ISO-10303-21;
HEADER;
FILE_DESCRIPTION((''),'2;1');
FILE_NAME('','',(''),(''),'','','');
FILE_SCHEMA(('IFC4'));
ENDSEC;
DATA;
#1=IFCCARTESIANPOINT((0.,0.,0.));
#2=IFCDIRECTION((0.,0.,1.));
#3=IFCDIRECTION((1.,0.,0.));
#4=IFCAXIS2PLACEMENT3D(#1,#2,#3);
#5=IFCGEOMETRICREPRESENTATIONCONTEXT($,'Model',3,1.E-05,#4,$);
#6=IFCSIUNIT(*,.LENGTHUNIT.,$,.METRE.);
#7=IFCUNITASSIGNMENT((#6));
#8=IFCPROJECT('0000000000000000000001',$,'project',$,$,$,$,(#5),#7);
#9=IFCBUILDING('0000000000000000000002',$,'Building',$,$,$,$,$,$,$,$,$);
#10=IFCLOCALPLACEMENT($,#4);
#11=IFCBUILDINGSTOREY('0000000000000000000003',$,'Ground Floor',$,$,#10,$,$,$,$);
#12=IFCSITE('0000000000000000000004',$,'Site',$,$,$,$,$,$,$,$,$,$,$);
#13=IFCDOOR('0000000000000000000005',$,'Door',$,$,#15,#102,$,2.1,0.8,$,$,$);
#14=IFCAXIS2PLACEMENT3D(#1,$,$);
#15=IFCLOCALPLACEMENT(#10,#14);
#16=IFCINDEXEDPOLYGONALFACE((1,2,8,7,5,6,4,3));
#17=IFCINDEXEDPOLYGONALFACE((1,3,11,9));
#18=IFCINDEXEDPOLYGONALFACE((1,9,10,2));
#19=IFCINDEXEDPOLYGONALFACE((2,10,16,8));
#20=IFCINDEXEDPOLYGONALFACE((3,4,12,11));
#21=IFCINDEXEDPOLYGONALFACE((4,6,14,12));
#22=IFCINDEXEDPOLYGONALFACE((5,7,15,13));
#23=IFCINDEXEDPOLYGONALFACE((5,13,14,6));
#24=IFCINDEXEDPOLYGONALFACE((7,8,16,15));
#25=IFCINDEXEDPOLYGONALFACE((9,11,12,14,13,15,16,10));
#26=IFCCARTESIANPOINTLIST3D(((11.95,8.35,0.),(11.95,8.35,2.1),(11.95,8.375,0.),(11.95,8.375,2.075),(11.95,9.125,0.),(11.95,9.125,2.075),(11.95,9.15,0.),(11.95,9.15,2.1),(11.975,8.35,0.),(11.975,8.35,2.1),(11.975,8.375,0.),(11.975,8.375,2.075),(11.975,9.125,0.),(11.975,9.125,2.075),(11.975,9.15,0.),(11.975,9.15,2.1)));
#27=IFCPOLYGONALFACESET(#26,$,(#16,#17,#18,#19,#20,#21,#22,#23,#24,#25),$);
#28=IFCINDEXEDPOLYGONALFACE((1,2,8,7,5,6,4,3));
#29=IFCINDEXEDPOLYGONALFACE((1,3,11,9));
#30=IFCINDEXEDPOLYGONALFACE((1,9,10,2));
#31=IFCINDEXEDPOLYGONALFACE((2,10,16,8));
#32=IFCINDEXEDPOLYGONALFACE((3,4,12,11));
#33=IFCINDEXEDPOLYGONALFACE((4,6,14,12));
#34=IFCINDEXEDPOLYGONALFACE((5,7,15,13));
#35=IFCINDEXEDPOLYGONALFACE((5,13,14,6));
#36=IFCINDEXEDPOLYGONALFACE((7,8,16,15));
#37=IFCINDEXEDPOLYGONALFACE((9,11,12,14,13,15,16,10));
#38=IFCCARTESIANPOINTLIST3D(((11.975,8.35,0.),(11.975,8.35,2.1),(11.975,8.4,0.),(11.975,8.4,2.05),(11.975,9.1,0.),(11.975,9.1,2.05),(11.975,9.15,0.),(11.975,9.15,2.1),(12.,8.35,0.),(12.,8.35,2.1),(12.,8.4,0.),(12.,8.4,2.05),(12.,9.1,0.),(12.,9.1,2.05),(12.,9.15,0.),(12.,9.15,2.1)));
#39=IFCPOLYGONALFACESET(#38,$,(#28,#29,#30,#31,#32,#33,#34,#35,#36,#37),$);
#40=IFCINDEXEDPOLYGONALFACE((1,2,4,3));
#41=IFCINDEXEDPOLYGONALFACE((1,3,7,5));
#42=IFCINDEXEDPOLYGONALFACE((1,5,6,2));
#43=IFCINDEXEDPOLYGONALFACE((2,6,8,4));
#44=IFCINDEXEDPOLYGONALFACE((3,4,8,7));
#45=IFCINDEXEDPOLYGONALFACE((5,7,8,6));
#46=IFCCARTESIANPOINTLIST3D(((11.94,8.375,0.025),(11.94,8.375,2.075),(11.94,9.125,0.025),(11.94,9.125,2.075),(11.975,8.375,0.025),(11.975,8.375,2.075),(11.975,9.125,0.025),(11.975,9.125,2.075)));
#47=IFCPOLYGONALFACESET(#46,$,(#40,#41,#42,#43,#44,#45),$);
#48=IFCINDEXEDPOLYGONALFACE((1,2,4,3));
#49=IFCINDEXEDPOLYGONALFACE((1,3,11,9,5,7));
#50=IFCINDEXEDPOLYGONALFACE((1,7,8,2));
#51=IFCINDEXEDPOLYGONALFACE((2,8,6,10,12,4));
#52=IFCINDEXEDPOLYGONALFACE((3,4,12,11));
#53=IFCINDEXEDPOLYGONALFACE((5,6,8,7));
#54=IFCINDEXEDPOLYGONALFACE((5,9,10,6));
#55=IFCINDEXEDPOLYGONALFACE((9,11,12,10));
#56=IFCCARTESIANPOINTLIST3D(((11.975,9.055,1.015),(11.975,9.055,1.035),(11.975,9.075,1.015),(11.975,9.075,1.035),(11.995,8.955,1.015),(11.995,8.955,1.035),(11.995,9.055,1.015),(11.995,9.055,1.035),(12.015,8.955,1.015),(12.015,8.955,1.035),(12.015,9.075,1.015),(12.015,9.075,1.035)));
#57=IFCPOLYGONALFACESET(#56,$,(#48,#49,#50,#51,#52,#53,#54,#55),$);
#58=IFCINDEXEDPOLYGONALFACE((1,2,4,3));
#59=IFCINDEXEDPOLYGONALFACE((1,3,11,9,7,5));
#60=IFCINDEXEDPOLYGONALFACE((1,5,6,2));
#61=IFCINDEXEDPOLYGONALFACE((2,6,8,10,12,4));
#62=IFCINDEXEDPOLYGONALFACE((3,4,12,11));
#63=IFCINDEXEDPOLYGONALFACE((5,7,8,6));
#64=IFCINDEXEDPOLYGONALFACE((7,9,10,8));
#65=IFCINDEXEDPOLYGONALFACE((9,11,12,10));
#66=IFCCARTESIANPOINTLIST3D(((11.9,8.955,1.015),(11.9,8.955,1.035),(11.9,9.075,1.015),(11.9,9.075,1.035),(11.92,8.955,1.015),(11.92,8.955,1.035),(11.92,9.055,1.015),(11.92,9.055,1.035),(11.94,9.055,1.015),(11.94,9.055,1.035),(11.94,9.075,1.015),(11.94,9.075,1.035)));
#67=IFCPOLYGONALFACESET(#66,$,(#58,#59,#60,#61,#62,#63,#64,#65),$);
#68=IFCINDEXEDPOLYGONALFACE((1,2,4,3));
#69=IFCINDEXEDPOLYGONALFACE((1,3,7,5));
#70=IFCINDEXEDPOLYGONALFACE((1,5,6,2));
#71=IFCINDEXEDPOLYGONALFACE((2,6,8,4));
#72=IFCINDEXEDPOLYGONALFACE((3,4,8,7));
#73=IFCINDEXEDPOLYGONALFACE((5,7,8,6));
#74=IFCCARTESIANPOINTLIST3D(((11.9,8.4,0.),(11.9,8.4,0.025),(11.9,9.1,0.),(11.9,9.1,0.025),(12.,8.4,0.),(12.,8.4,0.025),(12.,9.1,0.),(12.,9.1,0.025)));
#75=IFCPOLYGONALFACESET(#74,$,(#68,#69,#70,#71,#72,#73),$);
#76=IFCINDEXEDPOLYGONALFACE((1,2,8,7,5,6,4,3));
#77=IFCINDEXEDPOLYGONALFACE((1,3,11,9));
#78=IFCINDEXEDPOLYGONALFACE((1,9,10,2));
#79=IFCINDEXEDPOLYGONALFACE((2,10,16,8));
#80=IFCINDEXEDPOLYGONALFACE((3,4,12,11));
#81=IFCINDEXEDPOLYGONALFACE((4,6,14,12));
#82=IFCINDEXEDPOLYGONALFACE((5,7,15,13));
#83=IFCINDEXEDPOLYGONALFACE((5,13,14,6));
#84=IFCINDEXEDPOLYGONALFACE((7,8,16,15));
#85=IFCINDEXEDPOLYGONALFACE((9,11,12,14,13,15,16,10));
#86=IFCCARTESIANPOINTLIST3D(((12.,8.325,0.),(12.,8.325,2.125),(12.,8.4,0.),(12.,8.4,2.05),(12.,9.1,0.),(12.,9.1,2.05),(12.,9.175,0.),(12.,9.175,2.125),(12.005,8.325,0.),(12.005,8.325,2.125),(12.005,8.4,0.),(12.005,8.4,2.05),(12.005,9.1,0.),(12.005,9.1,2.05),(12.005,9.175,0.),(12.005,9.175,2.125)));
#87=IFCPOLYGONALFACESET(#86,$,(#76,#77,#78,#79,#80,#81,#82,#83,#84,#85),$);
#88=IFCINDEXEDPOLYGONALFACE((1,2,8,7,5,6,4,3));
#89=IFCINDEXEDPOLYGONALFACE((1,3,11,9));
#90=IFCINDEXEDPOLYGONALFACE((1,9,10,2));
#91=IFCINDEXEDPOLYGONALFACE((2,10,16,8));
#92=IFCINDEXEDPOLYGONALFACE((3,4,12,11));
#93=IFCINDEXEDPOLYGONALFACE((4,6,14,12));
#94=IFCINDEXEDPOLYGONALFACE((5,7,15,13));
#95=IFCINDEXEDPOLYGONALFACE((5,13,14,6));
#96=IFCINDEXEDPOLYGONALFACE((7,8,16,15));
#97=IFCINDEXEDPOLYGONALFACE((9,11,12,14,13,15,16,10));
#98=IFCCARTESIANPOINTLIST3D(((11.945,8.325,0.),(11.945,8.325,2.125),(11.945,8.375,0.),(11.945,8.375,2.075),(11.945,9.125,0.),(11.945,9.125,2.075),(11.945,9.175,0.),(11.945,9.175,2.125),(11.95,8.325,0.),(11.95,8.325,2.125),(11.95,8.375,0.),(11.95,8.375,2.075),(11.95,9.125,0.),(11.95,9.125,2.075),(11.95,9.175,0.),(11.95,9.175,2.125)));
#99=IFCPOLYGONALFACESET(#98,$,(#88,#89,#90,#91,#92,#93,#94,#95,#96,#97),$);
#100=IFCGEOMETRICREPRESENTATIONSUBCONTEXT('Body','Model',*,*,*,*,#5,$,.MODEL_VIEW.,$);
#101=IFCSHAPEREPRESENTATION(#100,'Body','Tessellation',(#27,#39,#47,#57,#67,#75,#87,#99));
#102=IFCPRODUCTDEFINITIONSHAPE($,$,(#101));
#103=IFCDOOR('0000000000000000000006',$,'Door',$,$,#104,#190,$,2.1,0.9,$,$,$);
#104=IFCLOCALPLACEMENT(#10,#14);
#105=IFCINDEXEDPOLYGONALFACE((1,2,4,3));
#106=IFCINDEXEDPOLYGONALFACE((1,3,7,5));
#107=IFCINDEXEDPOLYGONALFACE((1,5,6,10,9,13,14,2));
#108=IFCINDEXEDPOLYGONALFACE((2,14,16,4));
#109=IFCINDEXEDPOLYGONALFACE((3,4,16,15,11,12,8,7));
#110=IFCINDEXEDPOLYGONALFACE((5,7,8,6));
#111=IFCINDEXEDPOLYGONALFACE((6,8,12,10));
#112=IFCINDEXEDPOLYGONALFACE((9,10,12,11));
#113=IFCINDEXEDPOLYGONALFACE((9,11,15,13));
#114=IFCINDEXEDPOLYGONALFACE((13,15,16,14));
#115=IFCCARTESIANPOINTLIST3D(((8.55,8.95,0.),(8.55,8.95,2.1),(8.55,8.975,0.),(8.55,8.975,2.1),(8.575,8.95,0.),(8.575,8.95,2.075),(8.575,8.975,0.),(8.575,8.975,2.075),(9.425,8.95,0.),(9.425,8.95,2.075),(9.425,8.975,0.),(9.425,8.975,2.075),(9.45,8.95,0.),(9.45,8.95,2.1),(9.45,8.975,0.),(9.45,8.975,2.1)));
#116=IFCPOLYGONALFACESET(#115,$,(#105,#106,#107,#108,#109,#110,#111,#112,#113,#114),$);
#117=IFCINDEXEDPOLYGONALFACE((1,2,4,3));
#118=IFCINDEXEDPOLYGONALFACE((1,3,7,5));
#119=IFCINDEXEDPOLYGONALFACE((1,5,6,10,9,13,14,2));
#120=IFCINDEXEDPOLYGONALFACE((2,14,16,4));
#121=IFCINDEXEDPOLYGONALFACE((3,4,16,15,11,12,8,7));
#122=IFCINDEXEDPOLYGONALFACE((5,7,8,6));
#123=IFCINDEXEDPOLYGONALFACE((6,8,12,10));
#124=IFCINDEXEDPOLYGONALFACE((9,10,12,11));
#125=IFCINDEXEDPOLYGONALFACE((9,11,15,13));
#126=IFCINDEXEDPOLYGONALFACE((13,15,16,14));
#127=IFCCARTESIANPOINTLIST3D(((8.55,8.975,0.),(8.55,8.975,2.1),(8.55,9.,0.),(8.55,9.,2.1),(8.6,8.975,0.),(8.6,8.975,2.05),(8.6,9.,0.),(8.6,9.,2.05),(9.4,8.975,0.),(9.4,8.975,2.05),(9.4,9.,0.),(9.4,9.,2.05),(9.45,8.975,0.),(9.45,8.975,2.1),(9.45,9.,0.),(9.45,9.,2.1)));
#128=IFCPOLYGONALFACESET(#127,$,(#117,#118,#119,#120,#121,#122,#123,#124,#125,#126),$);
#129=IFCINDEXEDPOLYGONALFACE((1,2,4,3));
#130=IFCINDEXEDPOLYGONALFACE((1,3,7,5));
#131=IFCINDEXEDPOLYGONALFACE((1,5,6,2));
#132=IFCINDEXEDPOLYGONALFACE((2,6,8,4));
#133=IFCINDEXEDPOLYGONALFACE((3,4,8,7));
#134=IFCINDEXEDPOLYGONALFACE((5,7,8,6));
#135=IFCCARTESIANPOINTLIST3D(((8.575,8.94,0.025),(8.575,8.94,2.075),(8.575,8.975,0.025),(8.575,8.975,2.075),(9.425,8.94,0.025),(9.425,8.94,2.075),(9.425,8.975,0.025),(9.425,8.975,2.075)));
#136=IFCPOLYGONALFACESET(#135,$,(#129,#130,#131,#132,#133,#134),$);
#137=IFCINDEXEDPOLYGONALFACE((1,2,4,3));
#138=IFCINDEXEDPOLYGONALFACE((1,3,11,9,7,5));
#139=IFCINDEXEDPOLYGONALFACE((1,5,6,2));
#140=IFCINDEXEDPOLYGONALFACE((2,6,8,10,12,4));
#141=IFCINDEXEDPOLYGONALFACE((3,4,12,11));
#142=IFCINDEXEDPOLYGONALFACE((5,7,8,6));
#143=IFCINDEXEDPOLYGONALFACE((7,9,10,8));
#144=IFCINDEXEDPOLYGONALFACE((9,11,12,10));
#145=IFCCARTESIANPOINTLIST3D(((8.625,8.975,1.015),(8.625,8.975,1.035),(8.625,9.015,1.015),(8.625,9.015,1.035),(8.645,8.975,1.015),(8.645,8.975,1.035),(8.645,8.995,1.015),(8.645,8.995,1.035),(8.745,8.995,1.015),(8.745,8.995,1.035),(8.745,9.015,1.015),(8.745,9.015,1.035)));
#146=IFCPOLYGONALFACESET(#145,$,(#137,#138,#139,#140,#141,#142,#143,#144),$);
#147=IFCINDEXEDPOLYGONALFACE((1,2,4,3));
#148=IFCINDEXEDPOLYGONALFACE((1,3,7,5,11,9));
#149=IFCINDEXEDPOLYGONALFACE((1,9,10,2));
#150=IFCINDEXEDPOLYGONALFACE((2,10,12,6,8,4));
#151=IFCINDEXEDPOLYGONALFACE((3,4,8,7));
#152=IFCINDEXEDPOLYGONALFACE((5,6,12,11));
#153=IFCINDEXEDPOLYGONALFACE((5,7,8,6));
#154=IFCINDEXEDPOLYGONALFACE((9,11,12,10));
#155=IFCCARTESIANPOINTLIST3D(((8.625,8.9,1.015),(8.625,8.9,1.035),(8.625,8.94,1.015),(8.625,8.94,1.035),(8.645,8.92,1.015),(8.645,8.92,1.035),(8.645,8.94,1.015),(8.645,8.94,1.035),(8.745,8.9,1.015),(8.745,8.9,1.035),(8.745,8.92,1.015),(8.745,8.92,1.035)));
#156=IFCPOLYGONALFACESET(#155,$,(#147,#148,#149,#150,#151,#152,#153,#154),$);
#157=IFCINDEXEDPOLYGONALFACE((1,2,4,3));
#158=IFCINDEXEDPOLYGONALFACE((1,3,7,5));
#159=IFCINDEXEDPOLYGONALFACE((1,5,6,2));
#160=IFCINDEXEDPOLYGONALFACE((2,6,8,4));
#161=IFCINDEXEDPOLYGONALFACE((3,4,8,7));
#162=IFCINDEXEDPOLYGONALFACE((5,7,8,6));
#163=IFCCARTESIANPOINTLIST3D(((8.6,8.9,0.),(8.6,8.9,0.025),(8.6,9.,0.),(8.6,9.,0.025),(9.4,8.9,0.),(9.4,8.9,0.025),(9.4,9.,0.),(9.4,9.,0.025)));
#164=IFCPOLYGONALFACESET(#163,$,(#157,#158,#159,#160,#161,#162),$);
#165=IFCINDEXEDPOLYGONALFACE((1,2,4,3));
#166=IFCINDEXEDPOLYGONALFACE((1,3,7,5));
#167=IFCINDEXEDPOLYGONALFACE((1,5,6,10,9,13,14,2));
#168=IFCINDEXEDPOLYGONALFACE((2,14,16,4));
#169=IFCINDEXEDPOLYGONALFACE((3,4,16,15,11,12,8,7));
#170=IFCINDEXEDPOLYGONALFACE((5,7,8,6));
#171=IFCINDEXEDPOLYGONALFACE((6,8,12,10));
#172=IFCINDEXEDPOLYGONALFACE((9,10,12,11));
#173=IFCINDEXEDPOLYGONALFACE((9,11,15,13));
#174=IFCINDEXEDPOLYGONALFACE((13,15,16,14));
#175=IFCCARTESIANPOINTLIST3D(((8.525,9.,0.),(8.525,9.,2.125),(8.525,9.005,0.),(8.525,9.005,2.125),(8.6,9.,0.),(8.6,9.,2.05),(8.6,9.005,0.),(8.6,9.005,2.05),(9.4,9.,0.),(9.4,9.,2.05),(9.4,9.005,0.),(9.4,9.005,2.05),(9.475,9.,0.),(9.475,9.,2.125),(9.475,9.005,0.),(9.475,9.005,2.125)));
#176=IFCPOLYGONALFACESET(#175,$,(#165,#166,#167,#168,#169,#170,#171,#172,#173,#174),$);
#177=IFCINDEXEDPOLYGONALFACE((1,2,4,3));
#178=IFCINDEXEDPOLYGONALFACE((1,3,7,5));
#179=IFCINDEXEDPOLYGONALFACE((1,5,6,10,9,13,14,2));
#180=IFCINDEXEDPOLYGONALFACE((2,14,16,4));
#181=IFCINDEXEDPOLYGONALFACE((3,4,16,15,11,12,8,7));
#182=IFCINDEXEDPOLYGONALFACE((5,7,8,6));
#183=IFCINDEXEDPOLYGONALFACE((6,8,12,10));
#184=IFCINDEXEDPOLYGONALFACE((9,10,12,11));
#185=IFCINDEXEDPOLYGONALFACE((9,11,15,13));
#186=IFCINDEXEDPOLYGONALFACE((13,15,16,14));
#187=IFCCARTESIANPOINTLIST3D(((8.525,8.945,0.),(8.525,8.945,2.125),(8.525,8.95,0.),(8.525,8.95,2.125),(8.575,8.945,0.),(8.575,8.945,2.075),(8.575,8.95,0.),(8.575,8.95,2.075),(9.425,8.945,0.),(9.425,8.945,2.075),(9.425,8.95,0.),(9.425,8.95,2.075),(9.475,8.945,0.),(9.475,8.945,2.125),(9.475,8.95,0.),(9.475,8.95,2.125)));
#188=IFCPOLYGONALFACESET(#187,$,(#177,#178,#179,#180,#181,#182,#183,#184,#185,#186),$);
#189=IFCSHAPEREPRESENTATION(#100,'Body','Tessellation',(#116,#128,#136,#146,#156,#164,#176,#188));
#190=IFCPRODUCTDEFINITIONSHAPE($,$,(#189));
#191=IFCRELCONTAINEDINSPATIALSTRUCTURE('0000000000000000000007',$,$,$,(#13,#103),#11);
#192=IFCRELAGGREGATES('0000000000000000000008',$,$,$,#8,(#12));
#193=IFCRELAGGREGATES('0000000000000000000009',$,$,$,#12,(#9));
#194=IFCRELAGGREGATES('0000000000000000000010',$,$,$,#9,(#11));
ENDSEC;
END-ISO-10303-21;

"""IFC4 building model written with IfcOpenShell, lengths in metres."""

from ifc_helpers import new_model, si_unit, frame, origin_with_axes, place, context, subcontext, project, spatial, line, indexed_curve, outline, extrude, element, save


model = new_model("IFC4")

# Units and contexts
model_context = context("Model", 3, precision=1e-05, world=origin_with_axes())
body_context = subcontext(model_context, "Body", "Model", "MODEL_VIEW")
ifc_project = project(units=[si_unit("LENGTHUNIT", "METRE")], contexts=[model_context])

# Site, building, storey
site = spatial("IfcSite", under=ifc_project, Name="Site")
building = spatial("IfcBuilding", under=site, Name="Building")
storey_placement = place(None, origin_with_axes())
storey = spatial("IfcBuildingStorey", under=building, at=storey_placement, Name="Ground Floor")

# Doors
door_1_placement = place(storey_placement, frame((12.0, 8.35, 0.0), z_axis=(0.0, 0.0, 1.0), x_axis=(0.0, 1.0, 0.0)))
element("IfcDoor", 1, at=door_1_placement, inside=storey, Name="Door", OverallHeight=2.1, OverallWidth=0.8, context=body_context, shape_type="SweptSolid", body=[
    extrude(outline(indexed_curve([(0.0, 0.0), (0.0, 2.1), (0.8, 2.1), (0.8, 0.0), (0.775, 0.0), (0.775, 2.075), (0.025, 2.075), (0.025, 0.0)], segments=[line(1, 2, 3, 4, 5, 6, 7, 8, 1)])), frame((0.0, 0.025, 0.0), z_axis=(0.0, -1.0, 0.0), x_axis=(1.0, 0.0, 0.0)), (0.0, 0.0, -1.0), 0.025),
    extrude(outline(indexed_curve([(0.0, 0.0), (0.0, 2.1), (0.8, 2.1), (0.8, 0.0), (0.75, 0.0), (0.75, 2.05), (0.05, 2.05), (0.05, 0.0)], segments=[line(1, 2, 3, 4, 5, 6, 7, 8, 1)])), frame((0.0, 0.0, 0.0), z_axis=(0.0, -1.0, 0.0), x_axis=(1.0, 0.0, 0.0)), (0.0, 0.0, -1.0), 0.025),
    extrude(outline(indexed_curve([(0.0, 0.0), (0.75, 0.0), (0.75, 0.035), (0.0, 0.035)], segments=[line(1, 2, 3, 4, 1)])), frame((0.025, 0.025, 0.025), z_axis=(0.0, 0.0, 1.0), x_axis=(1.0, 0.0, 0.0)), (0.0, 0.0, 1.0), 2.05),
    extrude(outline(indexed_curve([(0.0, 0.0), (0.0, -0.04), (-0.12, -0.04), (-0.12, -0.02), (-0.02, -0.02), (-0.02, 0.0)], segments=[line(1, 2, 3, 4, 5, 6, 1)])), frame((0.725, 0.025, 1.015), z_axis=(0.0, 0.0, 1.0), x_axis=(1.0, 0.0, 0.0)), (0.0, 0.0, 1.0), 0.02),
    extrude(outline(indexed_curve([(0.0, 0.0), (0.0, 0.04), (-0.12, 0.04), (-0.12, 0.02), (-0.02, 0.02), (-0.02, 0.0)], segments=[line(1, 2, 3, 4, 5, 6, 1)])), frame((0.725, 0.06, 1.015), z_axis=(0.0, 0.0, 1.0), x_axis=(1.0, 0.0, 0.0)), (0.0, 0.0, 1.0), 0.02),
    extrude(outline(indexed_curve([(0.0, 0.0), (0.7, 0.0), (0.7, 0.1), (0.0, 0.1)], segments=[line(1, 2, 3, 4, 1)])), frame((0.05, 0.0, 0.0), z_axis=(0.0, 0.0, 1.0), x_axis=(1.0, 0.0, 0.0)), (0.0, 0.0, 1.0), 0.025),
    extrude(outline(indexed_curve([(0.0, 0.0), (0.0, 2.125), (0.85, 2.125), (0.85, 0.0), (0.775, 0.0), (0.775, 2.05), (0.075, 2.05), (0.075, 0.0)], segments=[line(1, 2, 3, 4, 5, 6, 7, 8, 1)])), frame((-0.025, -0.005, 0.0), z_axis=(0.0, -1.0, 0.0), x_axis=(1.0, 0.0, 0.0)), (0.0, 0.0, -1.0), 0.005),
    extrude(outline(indexed_curve([(0.0, 0.0), (0.0, 2.125), (0.85, 2.125), (0.85, 0.0), (0.8, 0.0), (0.8, 2.075), (0.05, 2.075), (0.05, 0.0)], segments=[line(1, 2, 3, 4, 5, 6, 7, 8, 1)])), frame((-0.025, 0.05, 0.0), z_axis=(0.0, -1.0, 0.0), x_axis=(1.0, 0.0, 0.0)), (0.0, 0.0, -1.0), 0.005),
])
door_2_placement = place(storey_placement, frame((9.45, 9.0, 0.0), z_axis=(0.0, 0.0, 1.0), x_axis=(-1.0, 0.0, 0.0)))
element("IfcDoor", 2, at=door_2_placement, inside=storey, Name="Door", OverallHeight=2.1, OverallWidth=0.9, context=body_context, shape_type="SweptSolid", body=[
    extrude(outline(indexed_curve([(0.0, 0.0), (0.0, 2.1), (0.9, 2.1), (0.9, 0.0), (0.875, 0.0), (0.875, 2.075), (0.025, 2.075), (0.025, 0.0)], segments=[line(1, 2, 3, 4, 5, 6, 7, 8, 1)])), frame((0.0, 0.025, 0.0), z_axis=(0.0, -1.0, 0.0), x_axis=(1.0, 0.0, 0.0)), (0.0, 0.0, -1.0), 0.025),
    extrude(outline(indexed_curve([(0.0, 0.0), (0.0, 2.1), (0.9, 2.1), (0.9, 0.0), (0.85, 0.0), (0.85, 2.05), (0.05, 2.05), (0.05, 0.0)], segments=[line(1, 2, 3, 4, 5, 6, 7, 8, 1)])), frame((0.0, 0.0, 0.0), z_axis=(0.0, -1.0, 0.0), x_axis=(1.0, 0.0, 0.0)), (0.0, 0.0, -1.0), 0.025),
    extrude(outline(indexed_curve([(0.0, 0.0), (0.85, 0.0), (0.85, 0.035), (0.0, 0.035)], segments=[line(1, 2, 3, 4, 1)])), frame((0.025, 0.025, 0.025), z_axis=(0.0, 0.0, 1.0), x_axis=(1.0, 0.0, 0.0)), (0.0, 0.0, 1.0), 2.05),
    extrude(outline(indexed_curve([(0.0, 0.0), (0.0, -0.04), (-0.12, -0.04), (-0.12, -0.02), (-0.02, -0.02), (-0.02, 0.0)], segments=[line(1, 2, 3, 4, 5, 6, 1)])), frame((0.825, 0.025, 1.015), z_axis=(0.0, 0.0, 1.0), x_axis=(1.0, 0.0, 0.0)), (0.0, 0.0, 1.0), 0.02),
    extrude(outline(indexed_curve([(0.0, 0.0), (0.0, 0.04), (-0.12, 0.04), (-0.12, 0.02), (-0.02, 0.02), (-0.02, 0.0)], segments=[line(1, 2, 3, 4, 5, 6, 1)])), frame((0.825, 0.06, 1.015), z_axis=(0.0, 0.0, 1.0), x_axis=(1.0, 0.0, 0.0)), (0.0, 0.0, 1.0), 0.02),
    extrude(outline(indexed_curve([(0.0, 0.0), (0.8, 0.0), (0.8, 0.1), (0.0, 0.1)], segments=[line(1, 2, 3, 4, 1)])), frame((0.05, 0.0, 0.0), z_axis=(0.0, 0.0, 1.0), x_axis=(1.0, 0.0, 0.0)), (0.0, 0.0, 1.0), 0.025),
    extrude(outline(indexed_curve([(0.0, 0.0), (0.0, 2.125), (0.95, 2.125), (0.95, 0.0), (0.875, 0.0), (0.875, 2.05), (0.075, 2.05), (0.075, 0.0)], segments=[line(1, 2, 3, 4, 5, 6, 7, 8, 1)])), frame((-0.025, -0.005, 0.0), z_axis=(0.0, -1.0, 0.0), x_axis=(1.0, 0.0, 0.0)), (0.0, 0.0, -1.0), 0.005),
    extrude(outline(indexed_curve([(0.0, 0.0), (0.0, 2.125), (0.95, 2.125), (0.95, 0.0), (0.9, 0.0), (0.9, 2.075), (0.05, 2.075), (0.05, 0.0)], segments=[line(1, 2, 3, 4, 5, 6, 7, 8, 1)])), frame((-0.025, 0.05, 0.0), z_axis=(0.0, -1.0, 0.0), x_axis=(1.0, 0.0, 0.0)), (0.0, 0.0, -1.0), 0.005),
])

save(model, "model.ifc")
